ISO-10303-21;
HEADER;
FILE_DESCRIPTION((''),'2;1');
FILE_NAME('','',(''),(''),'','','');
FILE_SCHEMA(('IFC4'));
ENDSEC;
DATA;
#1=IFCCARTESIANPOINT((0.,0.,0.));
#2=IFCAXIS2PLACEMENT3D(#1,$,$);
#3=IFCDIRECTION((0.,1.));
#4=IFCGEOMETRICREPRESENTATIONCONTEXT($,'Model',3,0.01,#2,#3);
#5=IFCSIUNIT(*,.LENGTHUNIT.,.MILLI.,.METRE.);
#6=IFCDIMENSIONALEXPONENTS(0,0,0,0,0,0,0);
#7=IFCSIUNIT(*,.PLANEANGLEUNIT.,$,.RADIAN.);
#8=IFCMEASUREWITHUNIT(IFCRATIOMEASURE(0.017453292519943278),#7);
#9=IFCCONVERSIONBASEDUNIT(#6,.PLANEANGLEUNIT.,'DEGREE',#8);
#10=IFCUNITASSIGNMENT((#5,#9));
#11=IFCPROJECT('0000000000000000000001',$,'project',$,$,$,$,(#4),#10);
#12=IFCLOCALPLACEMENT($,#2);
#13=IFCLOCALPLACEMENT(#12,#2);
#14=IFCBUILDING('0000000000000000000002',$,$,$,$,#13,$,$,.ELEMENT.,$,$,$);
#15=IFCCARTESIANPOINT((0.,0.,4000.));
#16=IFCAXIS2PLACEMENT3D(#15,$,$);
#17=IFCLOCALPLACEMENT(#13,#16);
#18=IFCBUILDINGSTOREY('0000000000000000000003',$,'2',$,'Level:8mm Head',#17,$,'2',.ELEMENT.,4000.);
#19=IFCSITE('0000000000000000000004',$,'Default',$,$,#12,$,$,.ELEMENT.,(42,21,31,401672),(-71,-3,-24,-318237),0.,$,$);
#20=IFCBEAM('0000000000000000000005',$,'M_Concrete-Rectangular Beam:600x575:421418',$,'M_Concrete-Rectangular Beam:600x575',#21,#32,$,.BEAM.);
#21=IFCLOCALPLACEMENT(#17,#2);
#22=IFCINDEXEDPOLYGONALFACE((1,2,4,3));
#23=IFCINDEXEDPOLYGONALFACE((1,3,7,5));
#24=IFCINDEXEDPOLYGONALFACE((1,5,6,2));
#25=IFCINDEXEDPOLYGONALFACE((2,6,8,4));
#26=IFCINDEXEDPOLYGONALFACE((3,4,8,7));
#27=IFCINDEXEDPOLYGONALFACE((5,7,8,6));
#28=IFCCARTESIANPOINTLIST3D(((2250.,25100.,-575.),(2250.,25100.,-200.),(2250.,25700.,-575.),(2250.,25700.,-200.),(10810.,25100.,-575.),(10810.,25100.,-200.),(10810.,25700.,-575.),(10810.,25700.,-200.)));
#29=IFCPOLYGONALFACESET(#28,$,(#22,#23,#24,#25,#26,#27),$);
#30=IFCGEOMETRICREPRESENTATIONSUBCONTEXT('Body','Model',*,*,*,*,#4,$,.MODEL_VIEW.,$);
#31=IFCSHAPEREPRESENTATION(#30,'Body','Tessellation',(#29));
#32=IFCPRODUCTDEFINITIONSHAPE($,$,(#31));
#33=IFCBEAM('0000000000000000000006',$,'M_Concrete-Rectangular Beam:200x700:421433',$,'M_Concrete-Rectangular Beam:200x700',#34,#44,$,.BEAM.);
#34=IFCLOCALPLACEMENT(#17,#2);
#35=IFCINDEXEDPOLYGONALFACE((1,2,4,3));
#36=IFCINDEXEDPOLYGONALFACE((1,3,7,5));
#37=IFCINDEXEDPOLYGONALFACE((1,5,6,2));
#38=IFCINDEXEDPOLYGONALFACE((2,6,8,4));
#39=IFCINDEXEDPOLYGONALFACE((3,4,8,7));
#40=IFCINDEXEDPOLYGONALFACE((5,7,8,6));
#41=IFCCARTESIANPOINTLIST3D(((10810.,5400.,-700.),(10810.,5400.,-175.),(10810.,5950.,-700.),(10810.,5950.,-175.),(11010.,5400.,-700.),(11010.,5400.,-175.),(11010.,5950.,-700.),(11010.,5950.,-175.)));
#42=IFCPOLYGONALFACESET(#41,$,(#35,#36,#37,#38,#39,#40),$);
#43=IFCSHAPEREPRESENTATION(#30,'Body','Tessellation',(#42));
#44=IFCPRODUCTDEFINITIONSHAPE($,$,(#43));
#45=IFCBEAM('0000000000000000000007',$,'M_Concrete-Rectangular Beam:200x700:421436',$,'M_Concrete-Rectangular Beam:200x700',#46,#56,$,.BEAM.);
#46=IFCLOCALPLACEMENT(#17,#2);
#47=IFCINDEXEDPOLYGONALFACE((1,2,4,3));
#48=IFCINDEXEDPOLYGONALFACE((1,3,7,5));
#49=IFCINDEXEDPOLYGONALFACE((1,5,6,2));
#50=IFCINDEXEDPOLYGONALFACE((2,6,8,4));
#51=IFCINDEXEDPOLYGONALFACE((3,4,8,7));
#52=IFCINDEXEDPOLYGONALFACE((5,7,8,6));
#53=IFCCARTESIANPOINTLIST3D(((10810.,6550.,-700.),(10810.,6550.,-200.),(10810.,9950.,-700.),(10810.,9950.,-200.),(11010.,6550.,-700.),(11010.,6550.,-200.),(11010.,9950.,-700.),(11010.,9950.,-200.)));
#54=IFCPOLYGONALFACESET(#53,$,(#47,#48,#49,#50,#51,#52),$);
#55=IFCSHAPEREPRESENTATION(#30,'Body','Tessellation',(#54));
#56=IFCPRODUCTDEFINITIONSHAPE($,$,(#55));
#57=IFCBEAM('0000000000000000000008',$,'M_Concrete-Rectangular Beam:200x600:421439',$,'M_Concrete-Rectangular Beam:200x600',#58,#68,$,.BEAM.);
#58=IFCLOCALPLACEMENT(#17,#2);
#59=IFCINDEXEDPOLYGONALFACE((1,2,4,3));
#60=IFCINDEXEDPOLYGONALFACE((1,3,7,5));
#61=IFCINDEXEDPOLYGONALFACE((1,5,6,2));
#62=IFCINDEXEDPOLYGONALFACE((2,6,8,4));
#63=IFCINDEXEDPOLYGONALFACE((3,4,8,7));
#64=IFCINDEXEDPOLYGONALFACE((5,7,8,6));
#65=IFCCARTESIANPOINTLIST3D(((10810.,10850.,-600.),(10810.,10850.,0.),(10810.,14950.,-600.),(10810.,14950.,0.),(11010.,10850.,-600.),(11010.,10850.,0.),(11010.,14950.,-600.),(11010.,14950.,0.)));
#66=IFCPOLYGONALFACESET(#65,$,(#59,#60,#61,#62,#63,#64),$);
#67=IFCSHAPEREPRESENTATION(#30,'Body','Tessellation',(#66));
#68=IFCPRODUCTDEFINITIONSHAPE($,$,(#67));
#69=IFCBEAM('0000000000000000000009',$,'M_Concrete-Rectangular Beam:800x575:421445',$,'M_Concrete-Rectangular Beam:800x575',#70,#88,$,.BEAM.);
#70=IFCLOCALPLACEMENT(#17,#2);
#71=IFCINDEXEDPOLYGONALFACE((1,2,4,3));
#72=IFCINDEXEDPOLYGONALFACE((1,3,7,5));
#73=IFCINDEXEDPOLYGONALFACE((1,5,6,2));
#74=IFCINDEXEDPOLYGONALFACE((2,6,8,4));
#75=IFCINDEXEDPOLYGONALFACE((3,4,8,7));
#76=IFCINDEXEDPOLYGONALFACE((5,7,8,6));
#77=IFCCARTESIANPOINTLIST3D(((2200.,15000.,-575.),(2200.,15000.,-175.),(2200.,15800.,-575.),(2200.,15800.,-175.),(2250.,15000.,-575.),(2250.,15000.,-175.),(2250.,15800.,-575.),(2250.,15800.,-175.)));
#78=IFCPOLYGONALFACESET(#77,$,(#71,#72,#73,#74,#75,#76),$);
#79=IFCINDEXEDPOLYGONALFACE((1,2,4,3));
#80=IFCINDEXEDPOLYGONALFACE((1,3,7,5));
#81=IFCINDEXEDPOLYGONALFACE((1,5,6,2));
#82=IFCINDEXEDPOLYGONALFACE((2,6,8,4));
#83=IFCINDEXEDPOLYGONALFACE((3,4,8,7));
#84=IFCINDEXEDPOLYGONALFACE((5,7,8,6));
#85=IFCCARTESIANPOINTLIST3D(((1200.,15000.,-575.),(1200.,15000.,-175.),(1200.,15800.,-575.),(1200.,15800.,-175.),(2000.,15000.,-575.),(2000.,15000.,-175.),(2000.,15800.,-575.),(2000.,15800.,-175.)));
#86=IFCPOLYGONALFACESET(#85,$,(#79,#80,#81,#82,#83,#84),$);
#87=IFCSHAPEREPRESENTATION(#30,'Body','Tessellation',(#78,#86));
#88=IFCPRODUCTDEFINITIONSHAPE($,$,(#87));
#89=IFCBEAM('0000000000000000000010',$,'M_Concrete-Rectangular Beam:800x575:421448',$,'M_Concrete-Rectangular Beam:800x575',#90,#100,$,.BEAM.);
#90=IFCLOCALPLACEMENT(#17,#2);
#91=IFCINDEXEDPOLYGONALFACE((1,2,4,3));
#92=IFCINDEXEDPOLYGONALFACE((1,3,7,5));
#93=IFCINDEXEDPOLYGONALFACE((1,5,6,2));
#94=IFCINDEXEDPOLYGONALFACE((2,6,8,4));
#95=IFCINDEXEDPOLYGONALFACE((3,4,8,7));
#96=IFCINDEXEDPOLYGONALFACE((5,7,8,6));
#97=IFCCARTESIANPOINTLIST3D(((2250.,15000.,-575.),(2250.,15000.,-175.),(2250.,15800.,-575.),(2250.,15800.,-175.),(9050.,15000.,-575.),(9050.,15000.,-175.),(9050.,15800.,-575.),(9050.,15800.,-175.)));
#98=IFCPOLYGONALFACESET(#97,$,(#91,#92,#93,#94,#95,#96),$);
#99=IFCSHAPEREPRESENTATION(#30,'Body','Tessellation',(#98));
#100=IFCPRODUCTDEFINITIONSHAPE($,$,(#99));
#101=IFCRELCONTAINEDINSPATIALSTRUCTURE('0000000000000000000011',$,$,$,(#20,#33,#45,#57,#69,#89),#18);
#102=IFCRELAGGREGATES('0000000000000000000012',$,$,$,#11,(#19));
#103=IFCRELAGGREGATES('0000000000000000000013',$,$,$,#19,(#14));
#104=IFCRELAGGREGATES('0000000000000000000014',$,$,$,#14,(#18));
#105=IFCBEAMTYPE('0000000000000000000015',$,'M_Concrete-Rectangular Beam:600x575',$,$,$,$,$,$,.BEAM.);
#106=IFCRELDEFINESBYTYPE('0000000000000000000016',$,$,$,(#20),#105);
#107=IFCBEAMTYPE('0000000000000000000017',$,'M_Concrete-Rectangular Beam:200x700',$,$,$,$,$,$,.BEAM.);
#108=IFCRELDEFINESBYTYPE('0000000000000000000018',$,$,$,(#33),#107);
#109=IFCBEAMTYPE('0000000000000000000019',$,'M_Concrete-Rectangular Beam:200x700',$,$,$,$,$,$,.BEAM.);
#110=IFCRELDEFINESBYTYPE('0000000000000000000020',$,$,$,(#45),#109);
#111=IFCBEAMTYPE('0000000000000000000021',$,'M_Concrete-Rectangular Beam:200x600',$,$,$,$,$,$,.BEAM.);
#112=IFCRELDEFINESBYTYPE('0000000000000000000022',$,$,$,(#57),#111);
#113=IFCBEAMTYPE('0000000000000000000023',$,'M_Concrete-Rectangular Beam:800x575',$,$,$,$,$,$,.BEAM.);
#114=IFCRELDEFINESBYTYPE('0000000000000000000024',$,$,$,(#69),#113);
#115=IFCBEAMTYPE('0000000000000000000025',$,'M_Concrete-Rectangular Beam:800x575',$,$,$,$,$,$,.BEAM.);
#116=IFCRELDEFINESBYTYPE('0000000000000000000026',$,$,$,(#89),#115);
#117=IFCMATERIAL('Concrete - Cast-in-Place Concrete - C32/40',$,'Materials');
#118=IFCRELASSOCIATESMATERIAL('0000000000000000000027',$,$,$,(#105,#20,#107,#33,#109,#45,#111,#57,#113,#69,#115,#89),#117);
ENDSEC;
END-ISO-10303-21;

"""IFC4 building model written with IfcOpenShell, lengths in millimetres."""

from ifc_helpers import new_model, entity, si_unit, converted_unit, direction, frame, origin, place, context, subcontext, project, spatial, indexed_curve, outline, extrude, source, transform, mapped, material, type_object, type_shapes, element, save


model = new_model("IFC4")

# Units and contexts
model_context = context("Model", 3, precision=0.01, world=origin(), true_north=direction((0.0, 1.0)))
body_context = subcontext(model_context, "Body", "Model", "MODEL_VIEW")
ifc_project = project(units=[si_unit("LENGTHUNIT", "METRE", prefix="MILLI"), converted_unit("PLANEANGLEUNIT", "DEGREE", entity("IfcRatioMeasure", 0.017453292519943278), si_unit("PLANEANGLEUNIT", "RADIAN"), dimensions=[0, 0, 0, 0, 0, 0, 0])], contexts=[model_context])

# Site, building, storey
site_placement = place(None, origin())
site = spatial("IfcSite", under=ifc_project, at=site_placement, Name="Default", CompositionType="ELEMENT", RefLatitude=(42, 21, 31, 401672), RefLongitude=(-71, -3, -24, -318237), RefElevation=0.0)
building_placement = place(site_placement, origin())
building = spatial("IfcBuilding", under=site, at=building_placement, CompositionType="ELEMENT")
storey_placement = place(building_placement, frame((0.0, 0.0, 4000.0)))
storey = spatial("IfcBuildingStorey", under=building, at=storey_placement, Name="2", ObjectType="Level:8mm Head", LongName="2", CompositionType="ELEMENT", Elevation=4000.0)

# Beams
ifc_material_1 = material(Name="Concrete - Cast-in-Place Concrete - C32/40", Category="Materials")
beam_type_1 = type_object("IfcBeamType", Name="M_Concrete-Rectangular Beam:600x575", PredefinedType="BEAM", material=ifc_material_1)
shared_shape_1 = source(origin(), body_context, "Body", "SweptSolid", [
    extrude(outline(indexed_curve([(-187.5, -300.0), (187.5, -300.0), (187.5, 300.0), (-187.5, 300.0), (-187.5, -300.0)], self_intersect=False)), frame((2250.0, 25400.0, 3612.5), z_axis=(1.0, 0.0, 0.0), x_axis=(0.0, 0.0, -1.0)), (0.0, 0.0, 1.0), 8560.0),
])
type_shapes(beam_type_1, [shared_shape_1])
beam_1_placement = place(storey_placement, frame((0.0, 0.0, -4000.0)))
element("IfcBeam", 1, at=beam_1_placement, inside=storey, type_object=beam_type_1, material=ifc_material_1, Name="M_Concrete-Rectangular Beam:600x575:421418", ObjectType="M_Concrete-Rectangular Beam:600x575", PredefinedType="BEAM", context=body_context, shape_type="MappedRepresentation", body=[
    mapped(shared_shape_1, transform((0.0, 0.0, 0.0), scale=1.0)),
])
beam_type_2 = type_object("IfcBeamType", Name="M_Concrete-Rectangular Beam:200x700", PredefinedType="BEAM", material=ifc_material_1)
shared_shape_2 = source(origin(), body_context, "Body", "SweptSolid", [
    extrude(outline(indexed_curve([(-100.0, -262.5), (100.0, -262.5), (100.0, 262.5), (-100.0, 262.5), (-100.0, -262.5)], self_intersect=False)), frame((10910.0, 5400.0, 3562.5), z_axis=(0.0, 1.0, 0.0), x_axis=(-1.0, 0.0, 0.0)), (0.0, 0.0, 1.0), 550.0),
])
type_shapes(beam_type_2, [shared_shape_2])
beam_2_placement = place(storey_placement, frame((0.0, 0.0, -4000.0)))
element("IfcBeam", 2, at=beam_2_placement, inside=storey, type_object=beam_type_2, material=ifc_material_1, Name="M_Concrete-Rectangular Beam:200x700:421433", ObjectType="M_Concrete-Rectangular Beam:200x700", PredefinedType="BEAM", context=body_context, shape_type="MappedRepresentation", body=[
    mapped(shared_shape_2, transform((0.0, 0.0, 0.0), scale=1.0)),
])
beam_type_3 = type_object("IfcBeamType", Name="M_Concrete-Rectangular Beam:200x700", PredefinedType="BEAM", material=ifc_material_1)
shared_shape_3 = source(origin(), body_context, "Body", "SweptSolid", [
    extrude(outline(indexed_curve([(-100.0, -250.0), (100.0, -250.0), (100.0, 250.0), (-100.0, 250.0), (-100.0, -250.0)], self_intersect=False)), frame((10910.0, 6550.0, 3550.0), z_axis=(0.0, 1.0, 0.0), x_axis=(-1.0, 0.0, 0.0)), (0.0, 0.0, 1.0), 3400.0),
])
type_shapes(beam_type_3, [shared_shape_3])
beam_3_placement = place(storey_placement, frame((0.0, 0.0, -4000.0)))
element("IfcBeam", 3, at=beam_3_placement, inside=storey, type_object=beam_type_3, material=ifc_material_1, Name="M_Concrete-Rectangular Beam:200x700:421436", ObjectType="M_Concrete-Rectangular Beam:200x700", PredefinedType="BEAM", context=body_context, shape_type="MappedRepresentation", body=[
    mapped(shared_shape_3, transform((0.0, 0.0, 0.0), scale=1.0)),
])
beam_type_4 = type_object("IfcBeamType", Name="M_Concrete-Rectangular Beam:200x600", PredefinedType="BEAM", material=ifc_material_1)
shared_shape_4 = source(origin(), body_context, "Body", "SweptSolid", [
    extrude(outline(indexed_curve([(-100.0, -300.0), (100.0, -300.0), (100.0, 300.0), (-100.0, 300.0), (-100.0, -300.0)], self_intersect=False)), frame((10910.0, 10850.0, 3700.0), z_axis=(0.0, 1.0, 0.0), x_axis=(-1.0, 0.0, 0.0)), (0.0, 0.0, 1.0), 4100.0),
])
type_shapes(beam_type_4, [shared_shape_4])
beam_4_placement = place(storey_placement, frame((0.0, 0.0, -4000.0)))
element("IfcBeam", 4, at=beam_4_placement, inside=storey, type_object=beam_type_4, material=ifc_material_1, Name="M_Concrete-Rectangular Beam:200x600:421439", ObjectType="M_Concrete-Rectangular Beam:200x600", PredefinedType="BEAM", context=body_context, shape_type="MappedRepresentation", body=[
    mapped(shared_shape_4, transform((0.0, 0.0, 0.0), scale=1.0)),
])
beam_type_5 = type_object("IfcBeamType", Name="M_Concrete-Rectangular Beam:800x575", PredefinedType="BEAM", material=ifc_material_1)
shared_shape_5 = source(origin(), body_context, "Body", "SweptSolid", [
    extrude(outline(indexed_curve([(-200.0, -400.0), (200.0, -400.0), (200.0, 400.0), (-200.0, 400.0), (-200.0, -400.0)], self_intersect=False)), frame((2200.0, 15400.0, 3625.0), z_axis=(1.0, 0.0, 0.0), x_axis=(0.0, 0.0, -1.0)), (0.0, 0.0, 1.0), 50.0),
    extrude(outline(indexed_curve([(-200.0, -400.0), (200.0, -400.0), (200.0, 400.0), (-200.0, 400.0), (-200.0, -400.0)], self_intersect=False)), frame((1200.0, 15400.0, 3625.0), z_axis=(1.0, 0.0, 0.0), x_axis=(0.0, 0.0, -1.0)), (0.0, 0.0, 1.0), 800.0),
])
type_shapes(beam_type_5, [shared_shape_5])
beam_5_placement = place(storey_placement, frame((0.0, 0.0, -4000.0)))
element("IfcBeam", 5, at=beam_5_placement, inside=storey, type_object=beam_type_5, material=ifc_material_1, Name="M_Concrete-Rectangular Beam:800x575:421445", ObjectType="M_Concrete-Rectangular Beam:800x575", PredefinedType="BEAM", context=body_context, shape_type="MappedRepresentation", body=[
    mapped(shared_shape_5, transform((0.0, 0.0, 0.0), scale=1.0)),
])
beam_type_6 = type_object("IfcBeamType", Name="M_Concrete-Rectangular Beam:800x575", PredefinedType="BEAM", material=ifc_material_1)
shared_shape_6 = source(origin(), body_context, "Body", "SweptSolid", [
    extrude(outline(indexed_curve([(-200.0, -400.0), (200.0, -400.0), (200.0, 400.0), (-200.0, 400.0), (-200.0, -400.0)], self_intersect=False)), frame((2250.0, 15400.0, 3625.0), z_axis=(1.0, 0.0, 0.0), x_axis=(0.0, 0.0, -1.0)), (0.0, 0.0, 1.0), 6800.0),
])
type_shapes(beam_type_6, [shared_shape_6])
beam_6_placement = place(storey_placement, frame((0.0, 0.0, -4000.0)))
element("IfcBeam", 6, at=beam_6_placement, inside=storey, type_object=beam_type_6, material=ifc_material_1, Name="M_Concrete-Rectangular Beam:800x575:421448", ObjectType="M_Concrete-Rectangular Beam:800x575", PredefinedType="BEAM", context=body_context, shape_type="MappedRepresentation", body=[
    mapped(shared_shape_6, transform((0.0, 0.0, 0.0), scale=1.0)),
])

save(model, "model.ifc")
